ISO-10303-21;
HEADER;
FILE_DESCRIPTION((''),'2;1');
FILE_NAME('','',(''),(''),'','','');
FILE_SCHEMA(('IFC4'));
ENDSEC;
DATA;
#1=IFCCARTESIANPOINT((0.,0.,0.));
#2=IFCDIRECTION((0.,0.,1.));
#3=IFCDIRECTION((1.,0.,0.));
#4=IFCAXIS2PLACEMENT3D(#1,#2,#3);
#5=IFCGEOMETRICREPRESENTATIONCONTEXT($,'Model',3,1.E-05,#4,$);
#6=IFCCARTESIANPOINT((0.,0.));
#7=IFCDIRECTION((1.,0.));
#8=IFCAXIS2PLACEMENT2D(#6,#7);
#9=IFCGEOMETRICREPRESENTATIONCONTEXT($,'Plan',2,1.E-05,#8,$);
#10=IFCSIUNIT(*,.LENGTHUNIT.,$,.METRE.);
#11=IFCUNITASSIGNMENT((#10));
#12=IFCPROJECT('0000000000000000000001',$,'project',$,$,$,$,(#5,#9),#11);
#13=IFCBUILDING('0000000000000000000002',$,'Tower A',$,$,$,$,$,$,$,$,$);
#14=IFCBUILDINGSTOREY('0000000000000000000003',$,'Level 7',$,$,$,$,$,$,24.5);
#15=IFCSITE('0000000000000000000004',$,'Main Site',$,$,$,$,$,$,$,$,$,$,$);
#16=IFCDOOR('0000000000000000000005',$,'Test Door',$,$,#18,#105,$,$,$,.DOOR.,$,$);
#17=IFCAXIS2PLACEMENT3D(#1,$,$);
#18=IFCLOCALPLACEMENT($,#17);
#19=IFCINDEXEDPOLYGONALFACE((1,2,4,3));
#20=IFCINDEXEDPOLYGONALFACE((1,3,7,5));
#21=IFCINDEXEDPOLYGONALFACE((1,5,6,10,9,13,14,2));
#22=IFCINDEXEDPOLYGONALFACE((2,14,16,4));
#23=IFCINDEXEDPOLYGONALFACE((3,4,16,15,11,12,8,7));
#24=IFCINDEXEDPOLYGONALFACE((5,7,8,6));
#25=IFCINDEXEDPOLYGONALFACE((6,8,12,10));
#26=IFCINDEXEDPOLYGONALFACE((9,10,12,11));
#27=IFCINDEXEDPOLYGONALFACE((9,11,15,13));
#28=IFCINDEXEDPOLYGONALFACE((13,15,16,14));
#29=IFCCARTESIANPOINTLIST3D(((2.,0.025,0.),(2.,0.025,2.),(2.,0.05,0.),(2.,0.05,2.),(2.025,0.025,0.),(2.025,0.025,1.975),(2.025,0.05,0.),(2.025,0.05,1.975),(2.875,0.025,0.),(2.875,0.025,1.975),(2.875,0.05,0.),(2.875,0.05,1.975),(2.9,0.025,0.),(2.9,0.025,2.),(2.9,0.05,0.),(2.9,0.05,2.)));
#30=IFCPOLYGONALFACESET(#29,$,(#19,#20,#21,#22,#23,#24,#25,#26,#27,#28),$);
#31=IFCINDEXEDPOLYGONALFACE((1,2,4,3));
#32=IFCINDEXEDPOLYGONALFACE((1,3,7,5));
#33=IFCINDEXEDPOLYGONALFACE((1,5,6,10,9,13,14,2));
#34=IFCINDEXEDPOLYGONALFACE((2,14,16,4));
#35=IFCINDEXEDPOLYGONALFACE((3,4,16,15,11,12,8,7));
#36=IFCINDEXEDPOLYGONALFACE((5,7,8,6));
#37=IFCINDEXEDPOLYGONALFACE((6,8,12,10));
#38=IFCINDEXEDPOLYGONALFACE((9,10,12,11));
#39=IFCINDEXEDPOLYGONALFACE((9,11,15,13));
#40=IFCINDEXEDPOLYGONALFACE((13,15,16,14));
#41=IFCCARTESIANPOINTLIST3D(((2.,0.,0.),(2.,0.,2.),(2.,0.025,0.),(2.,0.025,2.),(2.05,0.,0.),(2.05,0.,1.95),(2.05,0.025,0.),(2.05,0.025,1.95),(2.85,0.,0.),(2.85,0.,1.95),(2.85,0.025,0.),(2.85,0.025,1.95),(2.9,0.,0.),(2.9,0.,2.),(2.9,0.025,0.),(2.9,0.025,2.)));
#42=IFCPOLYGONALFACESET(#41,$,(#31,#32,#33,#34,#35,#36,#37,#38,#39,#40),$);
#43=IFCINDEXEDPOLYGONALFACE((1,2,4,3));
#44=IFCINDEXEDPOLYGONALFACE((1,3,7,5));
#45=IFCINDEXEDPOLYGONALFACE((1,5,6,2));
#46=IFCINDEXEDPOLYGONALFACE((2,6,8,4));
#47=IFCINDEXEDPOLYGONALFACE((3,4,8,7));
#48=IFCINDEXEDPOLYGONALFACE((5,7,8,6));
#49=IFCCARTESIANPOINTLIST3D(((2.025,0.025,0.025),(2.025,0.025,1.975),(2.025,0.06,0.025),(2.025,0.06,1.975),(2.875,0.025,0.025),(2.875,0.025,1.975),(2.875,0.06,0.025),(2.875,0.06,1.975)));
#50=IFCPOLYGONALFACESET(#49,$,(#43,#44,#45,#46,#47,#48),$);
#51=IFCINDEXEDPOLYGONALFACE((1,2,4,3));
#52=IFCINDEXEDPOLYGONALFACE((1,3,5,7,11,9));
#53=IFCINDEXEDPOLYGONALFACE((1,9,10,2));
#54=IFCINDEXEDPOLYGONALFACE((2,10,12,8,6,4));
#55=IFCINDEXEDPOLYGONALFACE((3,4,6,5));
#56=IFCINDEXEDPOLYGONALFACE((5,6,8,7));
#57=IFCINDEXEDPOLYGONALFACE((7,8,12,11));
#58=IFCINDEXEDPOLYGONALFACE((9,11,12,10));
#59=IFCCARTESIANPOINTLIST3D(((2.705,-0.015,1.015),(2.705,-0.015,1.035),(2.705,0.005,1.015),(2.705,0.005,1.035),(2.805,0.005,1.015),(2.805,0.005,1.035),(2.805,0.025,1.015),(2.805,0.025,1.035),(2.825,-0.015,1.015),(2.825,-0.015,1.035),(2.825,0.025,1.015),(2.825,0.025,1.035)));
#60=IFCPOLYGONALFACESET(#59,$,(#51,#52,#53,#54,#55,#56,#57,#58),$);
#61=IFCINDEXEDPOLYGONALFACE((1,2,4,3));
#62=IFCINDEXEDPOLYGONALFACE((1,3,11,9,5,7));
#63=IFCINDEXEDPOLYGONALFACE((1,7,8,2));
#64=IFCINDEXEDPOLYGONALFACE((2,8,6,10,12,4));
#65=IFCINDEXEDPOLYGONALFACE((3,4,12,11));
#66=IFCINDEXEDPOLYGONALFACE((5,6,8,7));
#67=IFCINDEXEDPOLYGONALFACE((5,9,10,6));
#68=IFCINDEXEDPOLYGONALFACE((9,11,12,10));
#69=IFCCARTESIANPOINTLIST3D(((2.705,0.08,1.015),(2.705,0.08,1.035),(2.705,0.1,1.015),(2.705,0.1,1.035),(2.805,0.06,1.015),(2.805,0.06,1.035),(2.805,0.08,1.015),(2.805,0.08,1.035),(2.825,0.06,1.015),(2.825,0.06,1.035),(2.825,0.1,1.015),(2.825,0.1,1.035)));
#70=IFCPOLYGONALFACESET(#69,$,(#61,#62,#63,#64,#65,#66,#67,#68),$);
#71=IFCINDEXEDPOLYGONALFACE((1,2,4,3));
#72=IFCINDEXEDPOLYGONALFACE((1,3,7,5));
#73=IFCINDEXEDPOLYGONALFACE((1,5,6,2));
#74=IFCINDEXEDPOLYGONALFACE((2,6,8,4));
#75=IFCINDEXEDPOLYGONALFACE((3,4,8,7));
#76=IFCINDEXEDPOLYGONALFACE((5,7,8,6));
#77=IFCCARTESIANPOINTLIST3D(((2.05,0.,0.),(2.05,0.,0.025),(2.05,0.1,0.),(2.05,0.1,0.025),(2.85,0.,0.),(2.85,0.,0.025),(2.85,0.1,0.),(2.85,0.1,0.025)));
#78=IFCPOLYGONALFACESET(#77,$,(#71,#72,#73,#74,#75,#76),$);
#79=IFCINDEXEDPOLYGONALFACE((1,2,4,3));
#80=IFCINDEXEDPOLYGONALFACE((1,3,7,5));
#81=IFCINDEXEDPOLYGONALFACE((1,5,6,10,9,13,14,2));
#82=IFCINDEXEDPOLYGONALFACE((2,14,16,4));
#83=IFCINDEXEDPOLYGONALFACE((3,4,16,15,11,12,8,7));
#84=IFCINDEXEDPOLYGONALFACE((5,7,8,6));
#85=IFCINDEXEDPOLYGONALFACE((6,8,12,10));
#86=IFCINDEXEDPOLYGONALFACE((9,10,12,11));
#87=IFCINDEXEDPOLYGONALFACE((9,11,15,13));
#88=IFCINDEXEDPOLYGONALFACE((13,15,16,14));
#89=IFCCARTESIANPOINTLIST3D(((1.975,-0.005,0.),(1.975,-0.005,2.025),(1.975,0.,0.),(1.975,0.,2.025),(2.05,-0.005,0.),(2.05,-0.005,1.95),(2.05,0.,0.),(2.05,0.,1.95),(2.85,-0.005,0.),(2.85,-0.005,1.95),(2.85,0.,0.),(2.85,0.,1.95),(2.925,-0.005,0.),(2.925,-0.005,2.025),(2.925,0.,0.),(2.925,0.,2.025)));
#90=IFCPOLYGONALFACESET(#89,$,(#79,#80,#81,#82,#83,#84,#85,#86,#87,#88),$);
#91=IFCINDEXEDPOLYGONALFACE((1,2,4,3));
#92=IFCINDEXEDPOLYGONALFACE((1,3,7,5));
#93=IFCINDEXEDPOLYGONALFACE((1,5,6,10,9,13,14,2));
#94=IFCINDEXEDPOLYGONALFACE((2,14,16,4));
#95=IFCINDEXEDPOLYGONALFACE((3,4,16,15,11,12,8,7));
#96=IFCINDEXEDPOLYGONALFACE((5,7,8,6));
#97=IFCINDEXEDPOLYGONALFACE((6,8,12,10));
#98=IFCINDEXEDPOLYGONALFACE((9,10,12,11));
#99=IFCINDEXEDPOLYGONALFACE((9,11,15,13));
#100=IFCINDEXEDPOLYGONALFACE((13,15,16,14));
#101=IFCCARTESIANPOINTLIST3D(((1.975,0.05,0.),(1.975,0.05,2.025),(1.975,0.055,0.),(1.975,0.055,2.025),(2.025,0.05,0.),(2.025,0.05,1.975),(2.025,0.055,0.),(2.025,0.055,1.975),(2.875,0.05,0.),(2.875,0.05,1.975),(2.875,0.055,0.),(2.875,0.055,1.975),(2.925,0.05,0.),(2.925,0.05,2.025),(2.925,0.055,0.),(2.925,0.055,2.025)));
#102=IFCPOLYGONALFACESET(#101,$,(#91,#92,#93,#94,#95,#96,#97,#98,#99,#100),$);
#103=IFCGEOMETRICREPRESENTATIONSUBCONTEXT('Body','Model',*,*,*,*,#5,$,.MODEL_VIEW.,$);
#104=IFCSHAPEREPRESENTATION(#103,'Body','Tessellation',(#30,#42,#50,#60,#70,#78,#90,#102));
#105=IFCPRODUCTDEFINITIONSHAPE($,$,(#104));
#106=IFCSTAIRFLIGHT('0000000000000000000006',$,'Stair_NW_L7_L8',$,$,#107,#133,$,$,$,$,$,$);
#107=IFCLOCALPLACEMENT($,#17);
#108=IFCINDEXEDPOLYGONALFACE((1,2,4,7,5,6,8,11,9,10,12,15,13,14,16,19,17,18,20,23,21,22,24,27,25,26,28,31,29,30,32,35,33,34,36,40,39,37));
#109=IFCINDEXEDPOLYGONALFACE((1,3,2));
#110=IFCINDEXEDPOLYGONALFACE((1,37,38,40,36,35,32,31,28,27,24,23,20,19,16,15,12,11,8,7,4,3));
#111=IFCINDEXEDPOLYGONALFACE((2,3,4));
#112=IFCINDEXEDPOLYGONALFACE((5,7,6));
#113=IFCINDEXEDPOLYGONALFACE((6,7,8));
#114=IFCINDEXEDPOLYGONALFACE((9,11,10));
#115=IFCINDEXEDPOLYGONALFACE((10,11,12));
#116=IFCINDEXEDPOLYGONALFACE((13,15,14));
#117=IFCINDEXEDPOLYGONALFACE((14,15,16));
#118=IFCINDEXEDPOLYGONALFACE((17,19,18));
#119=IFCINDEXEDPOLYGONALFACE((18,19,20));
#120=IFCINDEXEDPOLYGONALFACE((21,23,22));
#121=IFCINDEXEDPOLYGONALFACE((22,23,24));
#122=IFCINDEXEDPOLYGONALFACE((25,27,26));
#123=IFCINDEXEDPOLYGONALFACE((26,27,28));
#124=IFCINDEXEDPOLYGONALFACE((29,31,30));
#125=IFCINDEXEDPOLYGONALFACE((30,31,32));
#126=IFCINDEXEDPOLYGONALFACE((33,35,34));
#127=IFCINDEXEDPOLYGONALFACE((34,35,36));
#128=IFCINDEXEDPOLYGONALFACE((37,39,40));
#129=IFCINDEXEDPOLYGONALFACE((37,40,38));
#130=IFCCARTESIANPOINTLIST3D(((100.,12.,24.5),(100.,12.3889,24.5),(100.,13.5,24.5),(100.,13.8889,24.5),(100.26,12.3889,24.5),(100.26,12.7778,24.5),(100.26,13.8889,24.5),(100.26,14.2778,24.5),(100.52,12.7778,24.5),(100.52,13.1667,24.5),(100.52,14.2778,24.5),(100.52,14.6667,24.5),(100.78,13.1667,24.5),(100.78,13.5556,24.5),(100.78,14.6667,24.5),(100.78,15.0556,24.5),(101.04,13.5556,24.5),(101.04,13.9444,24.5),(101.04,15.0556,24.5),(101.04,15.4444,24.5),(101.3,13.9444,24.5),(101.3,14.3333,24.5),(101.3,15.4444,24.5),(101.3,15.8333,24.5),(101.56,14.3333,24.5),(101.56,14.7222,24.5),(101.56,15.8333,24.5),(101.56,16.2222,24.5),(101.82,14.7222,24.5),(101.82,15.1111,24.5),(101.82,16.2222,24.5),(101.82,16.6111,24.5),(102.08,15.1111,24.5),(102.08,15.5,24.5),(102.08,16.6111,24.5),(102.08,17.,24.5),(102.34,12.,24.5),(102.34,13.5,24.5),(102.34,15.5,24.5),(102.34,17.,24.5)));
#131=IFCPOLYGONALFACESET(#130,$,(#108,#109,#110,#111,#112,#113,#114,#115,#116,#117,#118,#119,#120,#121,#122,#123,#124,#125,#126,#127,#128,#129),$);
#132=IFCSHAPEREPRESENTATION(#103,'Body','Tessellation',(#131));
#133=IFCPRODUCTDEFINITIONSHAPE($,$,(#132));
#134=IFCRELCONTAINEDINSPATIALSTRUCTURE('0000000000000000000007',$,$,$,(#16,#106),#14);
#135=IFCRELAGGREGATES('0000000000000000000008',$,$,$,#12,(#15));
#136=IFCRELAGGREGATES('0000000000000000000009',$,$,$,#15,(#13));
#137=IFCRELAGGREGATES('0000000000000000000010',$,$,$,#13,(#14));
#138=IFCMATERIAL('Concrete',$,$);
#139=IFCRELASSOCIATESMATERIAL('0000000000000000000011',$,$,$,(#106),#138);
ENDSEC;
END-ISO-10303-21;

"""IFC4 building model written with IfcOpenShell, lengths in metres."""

from ifc_helpers import new_model, si_unit, frame, origin_with_axes, origin_2d_with_axis, place, context, subcontext, project, spatial, line, indexed_curve, outline, extrude, material, element, save


model = new_model("IFC4")

# Units and contexts
model_context = context("Model", 3, precision=1e-05, world=origin_with_axes())
plan_context = context("Plan", 2, precision=1e-05, world=origin_2d_with_axis())
body_context = subcontext(model_context, "Body", "Model", "MODEL_VIEW")
ifc_project = project(units=[si_unit("LENGTHUNIT", "METRE")], contexts=[model_context, plan_context])

# Site, building, storey
site = spatial("IfcSite", under=ifc_project, Name="Main Site")
building = spatial("IfcBuilding", under=site, Name="Tower A")
storey = spatial("IfcBuildingStorey", under=building, Name="Level 7", Elevation=24.5)

# Door
door_1_placement = place(None, frame((2.0, 0.0, 0.0), z_axis=(0.0, 0.0, 1.0), x_axis=(1.0, 0.0, 0.0)))
element("IfcDoor", 1, at=door_1_placement, inside=storey, Name="Test Door", PredefinedType="DOOR", context=body_context, shape_type="SweptSolid", body=[
    extrude(outline(indexed_curve([(0.0, 0.0), (0.0, 2.0), (0.9, 2.0), (0.9, 0.0), (0.875, 0.0), (0.875, 1.975), (0.025, 1.975), (0.025, 0.0)], segments=[line(1, 2, 3, 4, 5, 6, 7, 8, 1)])), frame((0.0, 0.025, 0.0), z_axis=(0.0, -1.0, 0.0), x_axis=(1.0, 0.0, 0.0)), (0.0, 0.0, -1.0), 0.025),
    extrude(outline(indexed_curve([(0.0, 0.0), (0.0, 2.0), (0.9, 2.0), (0.9, 0.0), (0.85, 0.0), (0.85, 1.95), (0.05, 1.95), (0.05, 0.0)], segments=[line(1, 2, 3, 4, 5, 6, 7, 8, 1)])), frame((0.0, 0.0, 0.0), z_axis=(0.0, -1.0, 0.0), x_axis=(1.0, 0.0, 0.0)), (0.0, 0.0, -1.0), 0.025),
    extrude(outline(indexed_curve([(0.0, 0.0), (0.85, 0.0), (0.85, 0.035), (0.0, 0.035)], segments=[line(1, 2, 3, 4, 1)])), frame((0.025, 0.025, 0.025), z_axis=(0.0, 0.0, 1.0), x_axis=(1.0, 0.0, 0.0)), (0.0, 0.0, 1.0), 1.95),
    extrude(outline(indexed_curve([(0.0, 0.0), (0.0, -0.04), (-0.12, -0.04), (-0.12, -0.02), (-0.02, -0.02), (-0.02, 0.0)], segments=[line(1, 2, 3, 4, 5, 6, 1)])), frame((0.825, 0.025, 1.015), z_axis=(0.0, 0.0, 1.0), x_axis=(1.0, 0.0, 0.0)), (0.0, 0.0, 1.0), 0.02),
    extrude(outline(indexed_curve([(0.0, 0.0), (0.0, 0.04), (-0.12, 0.04), (-0.12, 0.02), (-0.02, 0.02), (-0.02, 0.0)], segments=[line(1, 2, 3, 4, 5, 6, 1)])), frame((0.825, 0.06, 1.015), z_axis=(0.0, 0.0, 1.0), x_axis=(1.0, 0.0, 0.0)), (0.0, 0.0, 1.0), 0.02),
    extrude(outline(indexed_curve([(0.0, 0.0), (0.8, 0.0), (0.8, 0.1), (0.0, 0.1)], segments=[line(1, 2, 3, 4, 1)])), frame((0.05, 0.0, 0.0), z_axis=(0.0, 0.0, 1.0), x_axis=(1.0, 0.0, 0.0)), (0.0, 0.0, 1.0), 0.025),
    extrude(outline(indexed_curve([(0.0, 0.0), (0.0, 2.025), (0.95, 2.025), (0.95, 0.0), (0.875, 0.0), (0.875, 1.95), (0.075, 1.95), (0.075, 0.0)], segments=[line(1, 2, 3, 4, 5, 6, 7, 8, 1)])), frame((-0.025, -0.005, 0.0), z_axis=(0.0, -1.0, 0.0), x_axis=(1.0, 0.0, 0.0)), (0.0, 0.0, -1.0), 0.005),
    extrude(outline(indexed_curve([(0.0, 0.0), (0.0, 2.025), (0.95, 2.025), (0.95, 0.0), (0.9, 0.0), (0.9, 1.975), (0.05, 1.975), (0.05, 0.0)], segments=[line(1, 2, 3, 4, 5, 6, 7, 8, 1)])), frame((-0.025, 0.05, 0.0), z_axis=(0.0, -1.0, 0.0), x_axis=(1.0, 0.0, 0.0)), (0.0, 0.0, -1.0), 0.005),
])

# Stair flight
ifc_material_1 = material(Name="Concrete")
stair_flight_placement = place(None, frame((100.0, 12.0, 24.5), z_axis=(0.0, 0.0, 1.0), x_axis=(1.0, 0.0, 0.0)))
element("IfcStairFlight", 2, at=stair_flight_placement, inside=storey, material=ifc_material_1, Name="Stair_NW_L7_L8", context=body_context, shape_type="SweptSolid", body=[
    extrude(outline(indexed_curve([(0.0, 0.0), (0.0, 0.3889), (0.26, 0.3889), (0.26, 0.7778), (0.52, 0.7778), (0.52, 1.1667), (0.78, 1.1667), (0.78, 1.5556), (1.04, 1.5556), (1.04, 1.9444), (1.3, 1.9444), (1.3, 2.3333), (1.56, 2.3333), (1.56, 2.7222), (1.82, 2.7222), (1.82, 3.1111), (2.08, 3.1111), (2.08, 3.5), (2.34, 3.5), (2.34, 0.0)], segments=[line(1, 2, 3, 4, 5, 6, 7, 8, 9, 10, 11, 12, 13, 14, 15, 16, 17, 18, 19, 20, 1)])), origin_with_axes(), (0.0, 1.0, 0.0), 1.5),
])

save(model, "model.ifc")
